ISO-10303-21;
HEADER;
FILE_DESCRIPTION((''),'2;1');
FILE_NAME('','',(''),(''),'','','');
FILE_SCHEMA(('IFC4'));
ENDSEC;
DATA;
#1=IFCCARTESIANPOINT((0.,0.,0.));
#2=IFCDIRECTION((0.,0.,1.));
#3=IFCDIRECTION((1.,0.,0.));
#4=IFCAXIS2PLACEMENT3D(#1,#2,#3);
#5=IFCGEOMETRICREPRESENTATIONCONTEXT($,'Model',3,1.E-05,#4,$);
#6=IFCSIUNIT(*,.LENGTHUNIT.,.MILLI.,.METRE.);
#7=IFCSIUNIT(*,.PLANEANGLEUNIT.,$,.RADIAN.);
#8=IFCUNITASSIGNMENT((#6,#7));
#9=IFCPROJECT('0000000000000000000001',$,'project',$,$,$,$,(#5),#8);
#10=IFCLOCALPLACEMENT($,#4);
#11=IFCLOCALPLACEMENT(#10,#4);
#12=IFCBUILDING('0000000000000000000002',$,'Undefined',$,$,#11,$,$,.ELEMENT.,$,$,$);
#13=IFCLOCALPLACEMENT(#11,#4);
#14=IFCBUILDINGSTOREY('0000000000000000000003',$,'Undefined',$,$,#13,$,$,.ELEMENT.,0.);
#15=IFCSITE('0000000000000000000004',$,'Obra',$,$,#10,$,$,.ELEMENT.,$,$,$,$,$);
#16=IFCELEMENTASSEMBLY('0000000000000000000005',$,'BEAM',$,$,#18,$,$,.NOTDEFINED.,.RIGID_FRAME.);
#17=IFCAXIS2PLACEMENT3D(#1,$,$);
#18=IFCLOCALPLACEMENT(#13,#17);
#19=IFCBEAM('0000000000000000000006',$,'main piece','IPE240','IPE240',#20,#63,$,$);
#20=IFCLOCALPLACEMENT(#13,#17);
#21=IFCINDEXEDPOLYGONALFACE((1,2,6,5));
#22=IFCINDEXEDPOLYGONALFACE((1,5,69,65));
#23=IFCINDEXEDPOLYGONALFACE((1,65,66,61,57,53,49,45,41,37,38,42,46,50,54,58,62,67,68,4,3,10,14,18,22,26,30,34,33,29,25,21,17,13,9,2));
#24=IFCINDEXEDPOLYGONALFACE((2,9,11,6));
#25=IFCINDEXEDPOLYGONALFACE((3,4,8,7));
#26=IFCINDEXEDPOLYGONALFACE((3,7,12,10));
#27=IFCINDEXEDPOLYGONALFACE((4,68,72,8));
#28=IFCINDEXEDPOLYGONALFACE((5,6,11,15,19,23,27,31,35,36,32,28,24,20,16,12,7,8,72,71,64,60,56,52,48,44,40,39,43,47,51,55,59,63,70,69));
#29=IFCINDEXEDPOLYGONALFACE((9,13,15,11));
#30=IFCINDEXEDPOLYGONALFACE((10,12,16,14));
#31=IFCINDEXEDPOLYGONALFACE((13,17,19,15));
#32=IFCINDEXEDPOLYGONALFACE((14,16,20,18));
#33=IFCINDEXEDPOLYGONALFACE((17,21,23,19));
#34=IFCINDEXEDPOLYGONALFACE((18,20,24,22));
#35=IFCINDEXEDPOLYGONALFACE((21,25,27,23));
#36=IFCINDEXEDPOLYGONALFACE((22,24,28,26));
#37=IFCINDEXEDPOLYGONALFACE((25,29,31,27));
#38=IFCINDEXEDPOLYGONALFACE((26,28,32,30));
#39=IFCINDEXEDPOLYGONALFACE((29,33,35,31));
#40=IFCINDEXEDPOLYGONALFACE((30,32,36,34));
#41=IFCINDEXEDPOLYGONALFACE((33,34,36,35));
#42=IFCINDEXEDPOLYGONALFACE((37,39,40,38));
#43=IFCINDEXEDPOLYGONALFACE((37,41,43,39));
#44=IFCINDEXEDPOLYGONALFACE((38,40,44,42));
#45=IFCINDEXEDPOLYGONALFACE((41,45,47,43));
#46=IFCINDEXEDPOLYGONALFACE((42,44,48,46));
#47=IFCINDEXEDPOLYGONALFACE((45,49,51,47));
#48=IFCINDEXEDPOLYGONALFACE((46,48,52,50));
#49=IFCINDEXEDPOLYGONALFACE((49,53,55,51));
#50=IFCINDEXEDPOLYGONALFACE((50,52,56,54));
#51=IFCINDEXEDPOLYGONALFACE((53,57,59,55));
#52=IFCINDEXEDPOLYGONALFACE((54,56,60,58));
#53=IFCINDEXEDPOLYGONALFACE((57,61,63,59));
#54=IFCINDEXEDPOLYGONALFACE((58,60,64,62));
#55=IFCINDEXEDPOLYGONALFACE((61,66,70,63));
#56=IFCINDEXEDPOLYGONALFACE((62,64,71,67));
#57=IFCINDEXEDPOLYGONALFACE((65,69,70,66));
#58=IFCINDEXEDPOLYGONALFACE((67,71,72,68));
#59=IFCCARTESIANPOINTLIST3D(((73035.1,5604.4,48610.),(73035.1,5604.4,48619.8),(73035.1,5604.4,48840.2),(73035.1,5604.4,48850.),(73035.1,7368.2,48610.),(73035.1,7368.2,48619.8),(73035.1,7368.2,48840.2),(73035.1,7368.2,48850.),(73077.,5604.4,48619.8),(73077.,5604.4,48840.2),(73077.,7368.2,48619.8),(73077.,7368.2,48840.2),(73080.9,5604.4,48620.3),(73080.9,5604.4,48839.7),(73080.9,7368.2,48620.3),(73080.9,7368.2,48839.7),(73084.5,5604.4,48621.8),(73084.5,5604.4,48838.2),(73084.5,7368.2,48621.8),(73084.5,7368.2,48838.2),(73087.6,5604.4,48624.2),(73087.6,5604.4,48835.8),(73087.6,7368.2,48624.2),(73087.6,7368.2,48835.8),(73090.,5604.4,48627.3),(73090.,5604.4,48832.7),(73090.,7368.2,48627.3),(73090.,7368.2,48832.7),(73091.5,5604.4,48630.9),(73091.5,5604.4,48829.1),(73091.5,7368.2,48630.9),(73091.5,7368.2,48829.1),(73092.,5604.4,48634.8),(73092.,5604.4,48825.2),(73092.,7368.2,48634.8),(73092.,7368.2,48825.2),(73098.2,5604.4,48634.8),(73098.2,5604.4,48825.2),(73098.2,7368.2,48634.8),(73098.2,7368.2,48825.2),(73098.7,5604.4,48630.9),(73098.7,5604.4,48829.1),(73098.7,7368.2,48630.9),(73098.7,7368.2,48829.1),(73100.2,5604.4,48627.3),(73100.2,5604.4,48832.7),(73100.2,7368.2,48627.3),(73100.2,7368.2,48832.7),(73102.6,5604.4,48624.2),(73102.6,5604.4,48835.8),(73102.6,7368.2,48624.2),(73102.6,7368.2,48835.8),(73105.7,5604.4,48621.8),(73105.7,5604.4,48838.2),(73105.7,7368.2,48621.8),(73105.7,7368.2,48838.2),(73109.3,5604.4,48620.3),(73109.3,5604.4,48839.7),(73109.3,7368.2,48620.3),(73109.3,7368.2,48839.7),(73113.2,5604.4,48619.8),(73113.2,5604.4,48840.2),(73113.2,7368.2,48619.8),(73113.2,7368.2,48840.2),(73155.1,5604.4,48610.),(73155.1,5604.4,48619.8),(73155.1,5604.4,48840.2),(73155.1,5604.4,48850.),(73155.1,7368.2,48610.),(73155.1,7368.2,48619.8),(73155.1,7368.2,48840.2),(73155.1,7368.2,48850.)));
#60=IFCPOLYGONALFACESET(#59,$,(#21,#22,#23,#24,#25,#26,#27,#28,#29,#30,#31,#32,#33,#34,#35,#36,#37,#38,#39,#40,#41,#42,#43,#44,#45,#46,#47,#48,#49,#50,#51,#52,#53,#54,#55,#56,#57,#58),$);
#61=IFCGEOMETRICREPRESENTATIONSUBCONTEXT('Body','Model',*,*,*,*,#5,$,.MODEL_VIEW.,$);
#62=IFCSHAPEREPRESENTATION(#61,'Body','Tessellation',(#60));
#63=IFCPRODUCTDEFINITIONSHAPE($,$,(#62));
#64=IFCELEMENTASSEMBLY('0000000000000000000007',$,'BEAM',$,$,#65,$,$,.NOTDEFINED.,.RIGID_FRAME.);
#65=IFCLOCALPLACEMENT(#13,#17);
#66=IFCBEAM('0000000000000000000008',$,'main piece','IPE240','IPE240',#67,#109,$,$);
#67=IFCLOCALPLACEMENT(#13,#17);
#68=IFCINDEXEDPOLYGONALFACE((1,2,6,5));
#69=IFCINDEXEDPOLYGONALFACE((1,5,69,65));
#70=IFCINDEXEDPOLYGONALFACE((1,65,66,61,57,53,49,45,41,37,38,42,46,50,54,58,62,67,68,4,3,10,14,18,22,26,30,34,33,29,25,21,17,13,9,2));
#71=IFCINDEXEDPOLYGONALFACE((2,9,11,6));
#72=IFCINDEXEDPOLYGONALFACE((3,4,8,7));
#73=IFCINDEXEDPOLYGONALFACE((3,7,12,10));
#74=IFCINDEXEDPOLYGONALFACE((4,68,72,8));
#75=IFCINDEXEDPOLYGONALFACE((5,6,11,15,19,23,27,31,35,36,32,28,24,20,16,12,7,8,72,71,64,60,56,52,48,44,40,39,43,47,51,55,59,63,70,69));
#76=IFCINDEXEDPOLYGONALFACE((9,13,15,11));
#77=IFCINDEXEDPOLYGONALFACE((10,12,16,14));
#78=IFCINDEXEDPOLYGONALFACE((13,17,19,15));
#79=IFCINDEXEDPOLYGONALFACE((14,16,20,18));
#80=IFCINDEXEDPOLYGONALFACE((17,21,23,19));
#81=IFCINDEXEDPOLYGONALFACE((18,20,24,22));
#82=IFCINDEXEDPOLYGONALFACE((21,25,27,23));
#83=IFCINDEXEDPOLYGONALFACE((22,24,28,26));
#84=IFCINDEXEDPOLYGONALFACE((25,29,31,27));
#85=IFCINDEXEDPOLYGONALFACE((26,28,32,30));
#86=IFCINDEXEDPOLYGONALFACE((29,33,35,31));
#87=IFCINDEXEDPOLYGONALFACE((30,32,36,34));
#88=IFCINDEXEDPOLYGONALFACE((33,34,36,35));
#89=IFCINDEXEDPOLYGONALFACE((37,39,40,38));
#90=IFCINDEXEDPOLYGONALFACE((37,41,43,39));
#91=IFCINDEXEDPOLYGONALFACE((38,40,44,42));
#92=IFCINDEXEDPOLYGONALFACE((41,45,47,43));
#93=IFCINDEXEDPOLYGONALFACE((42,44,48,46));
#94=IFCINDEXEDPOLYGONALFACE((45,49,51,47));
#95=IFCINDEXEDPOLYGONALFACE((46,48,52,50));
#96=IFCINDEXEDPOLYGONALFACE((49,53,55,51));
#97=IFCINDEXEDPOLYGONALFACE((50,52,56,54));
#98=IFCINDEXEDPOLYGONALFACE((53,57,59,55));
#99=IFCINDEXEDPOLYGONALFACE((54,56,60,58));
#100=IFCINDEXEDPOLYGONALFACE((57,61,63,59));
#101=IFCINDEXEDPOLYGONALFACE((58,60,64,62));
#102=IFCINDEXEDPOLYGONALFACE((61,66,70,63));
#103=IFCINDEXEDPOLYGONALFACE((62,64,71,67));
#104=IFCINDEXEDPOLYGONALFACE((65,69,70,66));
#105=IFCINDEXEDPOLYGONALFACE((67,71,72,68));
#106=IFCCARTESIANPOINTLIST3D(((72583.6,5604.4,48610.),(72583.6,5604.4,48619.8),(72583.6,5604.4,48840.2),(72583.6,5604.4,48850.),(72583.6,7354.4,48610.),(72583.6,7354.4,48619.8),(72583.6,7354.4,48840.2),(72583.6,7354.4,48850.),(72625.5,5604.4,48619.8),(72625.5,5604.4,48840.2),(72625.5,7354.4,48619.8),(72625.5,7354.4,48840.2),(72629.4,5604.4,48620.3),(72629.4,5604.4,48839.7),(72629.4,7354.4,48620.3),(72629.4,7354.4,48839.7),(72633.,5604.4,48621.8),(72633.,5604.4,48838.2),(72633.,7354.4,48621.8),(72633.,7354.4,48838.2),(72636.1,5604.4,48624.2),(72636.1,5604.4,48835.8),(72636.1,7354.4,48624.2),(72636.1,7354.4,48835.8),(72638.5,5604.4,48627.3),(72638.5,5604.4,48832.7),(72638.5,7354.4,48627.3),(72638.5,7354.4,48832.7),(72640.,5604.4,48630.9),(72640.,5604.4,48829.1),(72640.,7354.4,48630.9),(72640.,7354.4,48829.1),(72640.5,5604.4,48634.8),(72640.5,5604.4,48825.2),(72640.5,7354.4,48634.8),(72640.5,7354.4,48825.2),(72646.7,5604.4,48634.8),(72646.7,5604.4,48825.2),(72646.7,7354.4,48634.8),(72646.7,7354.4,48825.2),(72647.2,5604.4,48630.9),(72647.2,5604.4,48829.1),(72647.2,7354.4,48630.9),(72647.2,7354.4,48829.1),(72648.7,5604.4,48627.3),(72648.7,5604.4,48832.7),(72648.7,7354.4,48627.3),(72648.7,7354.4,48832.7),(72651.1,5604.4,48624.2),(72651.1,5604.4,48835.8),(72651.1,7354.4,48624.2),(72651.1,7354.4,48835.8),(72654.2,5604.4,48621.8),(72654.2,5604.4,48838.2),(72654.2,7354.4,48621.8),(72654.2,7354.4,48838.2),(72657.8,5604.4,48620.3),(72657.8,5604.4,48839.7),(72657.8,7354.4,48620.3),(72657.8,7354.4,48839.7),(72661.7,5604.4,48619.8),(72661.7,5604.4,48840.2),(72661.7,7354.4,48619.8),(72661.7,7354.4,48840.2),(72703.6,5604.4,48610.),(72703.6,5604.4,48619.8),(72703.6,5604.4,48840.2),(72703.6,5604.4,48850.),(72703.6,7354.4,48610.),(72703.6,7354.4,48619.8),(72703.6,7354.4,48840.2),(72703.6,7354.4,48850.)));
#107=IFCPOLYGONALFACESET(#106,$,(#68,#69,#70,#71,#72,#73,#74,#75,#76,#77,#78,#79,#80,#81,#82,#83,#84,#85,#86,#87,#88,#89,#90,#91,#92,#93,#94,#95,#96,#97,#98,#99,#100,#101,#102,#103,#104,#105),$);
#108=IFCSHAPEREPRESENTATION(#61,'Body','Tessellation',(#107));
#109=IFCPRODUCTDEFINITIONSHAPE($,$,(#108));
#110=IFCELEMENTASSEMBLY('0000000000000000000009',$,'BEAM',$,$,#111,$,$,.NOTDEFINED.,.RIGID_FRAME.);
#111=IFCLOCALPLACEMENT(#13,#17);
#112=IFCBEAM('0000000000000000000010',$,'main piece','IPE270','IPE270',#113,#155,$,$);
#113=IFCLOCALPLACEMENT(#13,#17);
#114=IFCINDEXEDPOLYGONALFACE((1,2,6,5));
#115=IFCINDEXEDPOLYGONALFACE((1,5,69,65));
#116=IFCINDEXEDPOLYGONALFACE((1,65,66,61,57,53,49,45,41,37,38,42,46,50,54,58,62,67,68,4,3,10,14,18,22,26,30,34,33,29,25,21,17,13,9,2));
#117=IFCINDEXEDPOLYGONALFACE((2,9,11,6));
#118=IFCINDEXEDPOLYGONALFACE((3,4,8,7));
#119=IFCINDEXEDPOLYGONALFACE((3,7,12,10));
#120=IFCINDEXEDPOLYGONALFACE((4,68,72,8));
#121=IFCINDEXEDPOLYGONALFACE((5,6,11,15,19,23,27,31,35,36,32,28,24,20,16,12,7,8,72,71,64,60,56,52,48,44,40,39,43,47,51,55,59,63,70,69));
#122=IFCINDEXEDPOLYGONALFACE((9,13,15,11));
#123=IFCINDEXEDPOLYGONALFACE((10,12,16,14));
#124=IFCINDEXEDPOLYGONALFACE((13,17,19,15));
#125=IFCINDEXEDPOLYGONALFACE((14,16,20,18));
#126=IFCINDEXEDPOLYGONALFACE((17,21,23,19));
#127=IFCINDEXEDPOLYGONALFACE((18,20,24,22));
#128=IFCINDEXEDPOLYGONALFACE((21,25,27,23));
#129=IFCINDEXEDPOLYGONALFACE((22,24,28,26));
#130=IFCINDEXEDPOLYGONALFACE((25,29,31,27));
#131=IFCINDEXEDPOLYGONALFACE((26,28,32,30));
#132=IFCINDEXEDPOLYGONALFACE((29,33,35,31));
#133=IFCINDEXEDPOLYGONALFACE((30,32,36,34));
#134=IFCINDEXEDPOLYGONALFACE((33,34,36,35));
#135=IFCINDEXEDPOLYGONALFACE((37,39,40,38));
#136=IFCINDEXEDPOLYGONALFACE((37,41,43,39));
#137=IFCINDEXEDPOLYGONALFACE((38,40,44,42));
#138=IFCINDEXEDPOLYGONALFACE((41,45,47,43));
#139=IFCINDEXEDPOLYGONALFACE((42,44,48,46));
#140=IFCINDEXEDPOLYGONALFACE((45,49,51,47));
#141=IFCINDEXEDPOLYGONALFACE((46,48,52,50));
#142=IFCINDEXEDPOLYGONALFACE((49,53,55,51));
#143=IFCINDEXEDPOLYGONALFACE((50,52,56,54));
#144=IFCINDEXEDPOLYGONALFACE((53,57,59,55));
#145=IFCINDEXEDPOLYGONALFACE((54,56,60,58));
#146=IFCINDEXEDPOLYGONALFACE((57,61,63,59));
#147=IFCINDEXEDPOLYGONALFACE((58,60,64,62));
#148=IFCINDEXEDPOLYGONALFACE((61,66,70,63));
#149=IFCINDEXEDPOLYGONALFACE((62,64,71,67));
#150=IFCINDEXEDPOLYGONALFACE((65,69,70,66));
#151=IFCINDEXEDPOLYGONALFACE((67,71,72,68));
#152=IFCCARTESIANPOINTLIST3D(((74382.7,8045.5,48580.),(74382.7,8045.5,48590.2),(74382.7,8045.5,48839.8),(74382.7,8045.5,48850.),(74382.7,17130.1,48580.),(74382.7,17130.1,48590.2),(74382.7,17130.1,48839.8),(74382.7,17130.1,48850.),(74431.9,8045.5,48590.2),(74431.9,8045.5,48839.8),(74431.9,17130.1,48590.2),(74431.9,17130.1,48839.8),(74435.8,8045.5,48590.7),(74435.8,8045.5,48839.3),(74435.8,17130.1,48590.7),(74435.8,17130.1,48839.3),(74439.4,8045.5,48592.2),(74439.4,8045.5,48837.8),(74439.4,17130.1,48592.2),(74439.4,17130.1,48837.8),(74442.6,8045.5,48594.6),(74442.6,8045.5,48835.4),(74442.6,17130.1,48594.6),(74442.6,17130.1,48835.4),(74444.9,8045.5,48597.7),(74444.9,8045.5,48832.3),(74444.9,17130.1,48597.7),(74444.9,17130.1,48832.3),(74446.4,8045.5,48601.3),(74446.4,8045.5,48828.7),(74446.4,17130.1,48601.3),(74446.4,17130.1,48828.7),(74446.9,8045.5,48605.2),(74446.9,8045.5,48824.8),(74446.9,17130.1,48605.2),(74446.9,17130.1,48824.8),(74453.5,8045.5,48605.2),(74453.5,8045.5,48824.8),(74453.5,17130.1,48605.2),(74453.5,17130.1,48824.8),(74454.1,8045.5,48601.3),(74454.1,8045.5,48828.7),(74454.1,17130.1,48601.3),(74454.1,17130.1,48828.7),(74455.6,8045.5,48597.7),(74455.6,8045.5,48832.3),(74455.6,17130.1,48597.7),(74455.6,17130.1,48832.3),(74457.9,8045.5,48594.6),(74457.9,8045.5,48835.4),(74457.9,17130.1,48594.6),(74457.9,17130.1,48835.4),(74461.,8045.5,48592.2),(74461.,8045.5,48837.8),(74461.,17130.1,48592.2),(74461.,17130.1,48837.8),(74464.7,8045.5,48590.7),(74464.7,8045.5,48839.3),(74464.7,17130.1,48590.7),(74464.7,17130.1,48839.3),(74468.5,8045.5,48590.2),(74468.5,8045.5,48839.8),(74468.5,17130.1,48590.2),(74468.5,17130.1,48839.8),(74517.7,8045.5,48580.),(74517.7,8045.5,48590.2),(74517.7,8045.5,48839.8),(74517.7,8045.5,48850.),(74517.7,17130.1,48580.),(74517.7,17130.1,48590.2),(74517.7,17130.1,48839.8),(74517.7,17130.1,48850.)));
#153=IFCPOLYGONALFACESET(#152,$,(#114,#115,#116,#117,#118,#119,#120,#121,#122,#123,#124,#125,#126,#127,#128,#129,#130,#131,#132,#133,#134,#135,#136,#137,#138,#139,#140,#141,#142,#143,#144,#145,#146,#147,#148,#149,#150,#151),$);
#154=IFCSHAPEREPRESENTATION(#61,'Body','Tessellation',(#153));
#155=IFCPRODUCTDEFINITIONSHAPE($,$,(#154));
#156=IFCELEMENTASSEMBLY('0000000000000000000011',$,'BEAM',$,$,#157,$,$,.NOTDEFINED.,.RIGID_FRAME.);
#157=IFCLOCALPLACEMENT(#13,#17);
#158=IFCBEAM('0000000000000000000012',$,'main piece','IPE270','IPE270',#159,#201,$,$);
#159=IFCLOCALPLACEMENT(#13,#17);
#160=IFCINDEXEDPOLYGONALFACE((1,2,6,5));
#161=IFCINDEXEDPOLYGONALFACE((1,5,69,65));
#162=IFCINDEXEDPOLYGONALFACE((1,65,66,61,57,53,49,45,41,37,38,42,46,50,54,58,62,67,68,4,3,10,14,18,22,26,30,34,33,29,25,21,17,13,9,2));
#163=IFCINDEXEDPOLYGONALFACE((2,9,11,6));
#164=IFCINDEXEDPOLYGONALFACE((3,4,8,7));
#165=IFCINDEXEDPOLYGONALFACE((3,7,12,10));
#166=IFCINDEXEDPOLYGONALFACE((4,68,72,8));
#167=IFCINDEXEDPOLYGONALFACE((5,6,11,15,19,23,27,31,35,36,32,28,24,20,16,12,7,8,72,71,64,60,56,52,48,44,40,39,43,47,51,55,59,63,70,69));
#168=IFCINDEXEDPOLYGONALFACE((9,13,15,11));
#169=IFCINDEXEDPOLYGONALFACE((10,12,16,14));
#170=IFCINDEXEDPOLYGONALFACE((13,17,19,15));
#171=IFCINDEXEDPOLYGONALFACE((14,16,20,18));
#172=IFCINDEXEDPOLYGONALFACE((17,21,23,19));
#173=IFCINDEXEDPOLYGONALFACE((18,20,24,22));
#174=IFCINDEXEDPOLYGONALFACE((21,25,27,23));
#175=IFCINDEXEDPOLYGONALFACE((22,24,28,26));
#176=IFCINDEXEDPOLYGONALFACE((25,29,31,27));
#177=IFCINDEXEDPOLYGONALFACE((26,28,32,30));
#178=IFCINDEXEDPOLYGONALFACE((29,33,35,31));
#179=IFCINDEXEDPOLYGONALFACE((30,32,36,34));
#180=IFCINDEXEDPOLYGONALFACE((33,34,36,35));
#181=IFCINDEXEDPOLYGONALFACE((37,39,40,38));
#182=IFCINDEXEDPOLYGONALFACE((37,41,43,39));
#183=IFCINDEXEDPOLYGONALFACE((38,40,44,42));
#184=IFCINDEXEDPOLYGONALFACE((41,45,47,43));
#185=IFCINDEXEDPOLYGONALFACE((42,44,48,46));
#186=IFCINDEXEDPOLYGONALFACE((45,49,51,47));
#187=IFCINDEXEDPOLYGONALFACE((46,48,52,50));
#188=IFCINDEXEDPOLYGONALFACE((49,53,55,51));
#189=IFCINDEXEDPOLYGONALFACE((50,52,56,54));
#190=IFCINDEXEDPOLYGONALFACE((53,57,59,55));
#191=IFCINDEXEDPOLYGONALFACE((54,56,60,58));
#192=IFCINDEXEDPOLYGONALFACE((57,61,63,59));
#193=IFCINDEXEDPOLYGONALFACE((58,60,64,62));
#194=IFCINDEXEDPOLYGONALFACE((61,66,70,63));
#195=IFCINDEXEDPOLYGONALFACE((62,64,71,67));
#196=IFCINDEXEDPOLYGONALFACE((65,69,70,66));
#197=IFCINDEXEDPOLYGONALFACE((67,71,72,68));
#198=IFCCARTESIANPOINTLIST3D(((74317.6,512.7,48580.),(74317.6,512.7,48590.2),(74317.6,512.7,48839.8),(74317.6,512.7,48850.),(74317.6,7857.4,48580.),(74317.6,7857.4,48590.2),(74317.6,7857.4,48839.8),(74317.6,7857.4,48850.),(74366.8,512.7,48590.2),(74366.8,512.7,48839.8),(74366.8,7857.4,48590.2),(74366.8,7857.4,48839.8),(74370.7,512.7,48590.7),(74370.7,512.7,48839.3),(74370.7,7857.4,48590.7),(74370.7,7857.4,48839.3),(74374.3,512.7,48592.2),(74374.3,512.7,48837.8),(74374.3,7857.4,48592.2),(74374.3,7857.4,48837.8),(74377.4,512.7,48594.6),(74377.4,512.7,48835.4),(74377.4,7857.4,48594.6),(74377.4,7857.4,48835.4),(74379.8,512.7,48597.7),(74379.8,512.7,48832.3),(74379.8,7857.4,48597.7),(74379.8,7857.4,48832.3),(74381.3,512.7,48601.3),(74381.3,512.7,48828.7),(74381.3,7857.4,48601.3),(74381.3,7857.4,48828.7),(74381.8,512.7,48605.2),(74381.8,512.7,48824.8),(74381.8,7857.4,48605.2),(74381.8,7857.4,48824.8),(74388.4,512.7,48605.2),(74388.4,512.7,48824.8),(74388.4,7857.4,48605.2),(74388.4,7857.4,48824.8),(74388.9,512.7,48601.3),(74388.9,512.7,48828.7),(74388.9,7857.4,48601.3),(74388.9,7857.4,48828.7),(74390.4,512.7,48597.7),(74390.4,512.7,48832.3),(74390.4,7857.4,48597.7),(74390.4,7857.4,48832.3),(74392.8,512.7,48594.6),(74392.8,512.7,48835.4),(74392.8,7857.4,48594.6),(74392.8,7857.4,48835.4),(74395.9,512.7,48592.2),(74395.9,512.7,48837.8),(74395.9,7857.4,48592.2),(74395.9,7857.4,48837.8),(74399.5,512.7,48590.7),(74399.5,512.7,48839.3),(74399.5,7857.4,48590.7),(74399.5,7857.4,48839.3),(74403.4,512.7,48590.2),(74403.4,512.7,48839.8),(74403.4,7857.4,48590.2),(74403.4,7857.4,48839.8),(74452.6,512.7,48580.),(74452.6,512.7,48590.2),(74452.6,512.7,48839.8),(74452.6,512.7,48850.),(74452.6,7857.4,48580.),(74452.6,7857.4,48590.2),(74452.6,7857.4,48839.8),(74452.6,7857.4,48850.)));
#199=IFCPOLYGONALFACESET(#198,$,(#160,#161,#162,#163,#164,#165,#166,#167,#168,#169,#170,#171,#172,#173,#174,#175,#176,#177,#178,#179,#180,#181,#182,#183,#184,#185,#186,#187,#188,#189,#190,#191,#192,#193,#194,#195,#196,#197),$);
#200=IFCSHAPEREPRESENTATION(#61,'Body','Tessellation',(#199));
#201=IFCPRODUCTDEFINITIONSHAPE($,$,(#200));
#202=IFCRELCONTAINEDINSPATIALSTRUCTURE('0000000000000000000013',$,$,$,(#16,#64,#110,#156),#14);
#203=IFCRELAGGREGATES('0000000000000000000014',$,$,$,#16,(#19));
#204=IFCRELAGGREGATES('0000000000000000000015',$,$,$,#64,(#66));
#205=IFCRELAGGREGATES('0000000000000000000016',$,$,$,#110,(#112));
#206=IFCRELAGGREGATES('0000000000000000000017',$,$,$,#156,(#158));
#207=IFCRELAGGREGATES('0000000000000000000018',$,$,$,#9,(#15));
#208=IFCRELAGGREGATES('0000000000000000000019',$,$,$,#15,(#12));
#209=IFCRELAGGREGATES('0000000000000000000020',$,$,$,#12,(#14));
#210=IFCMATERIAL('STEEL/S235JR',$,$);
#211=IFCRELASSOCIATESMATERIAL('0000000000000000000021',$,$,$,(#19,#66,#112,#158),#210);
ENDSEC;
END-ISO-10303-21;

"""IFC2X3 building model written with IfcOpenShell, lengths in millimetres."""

from ifc_helpers import new_model, si_unit, frame, origin_with_axes, origin_2d_with_axis, place, context, subcontext, project, spatial, i_section, extrude, material, element, aggregate, save


model = new_model("IFC2X3")

# Units and contexts
model_context = context("Model", 3, precision=1e-05, world=origin_with_axes())
body_context = subcontext(model_context, "Body", "Model", "MODEL_VIEW")
ifc_project = project(units=[si_unit("LENGTHUNIT", "METRE", prefix="MILLI"), si_unit("PLANEANGLEUNIT", "RADIAN")], contexts=[model_context])

# Site, building, storey
site_placement = place(None, origin_with_axes())
site = spatial("IfcSite", under=ifc_project, at=site_placement, Name="Obra", CompositionType="ELEMENT")
building_placement = place(site_placement, origin_with_axes())
building = spatial("IfcBuilding", under=site, at=building_placement, Name="Undefined", CompositionType="ELEMENT")
storey_placement = place(building_placement, origin_with_axes())
storey = spatial("IfcBuildingStorey", under=building, at=storey_placement, Name="Undefined", CompositionType="ELEMENT", Elevation=0.0)

# Shared definitions
ifc_material_1 = material(Name="STEEL/S235JR")

# Element assemblies, beams
assembly_1_placement = place(storey_placement, origin_with_axes())
assembly_1 = element("IfcElementAssembly", 1, at=assembly_1_placement, inside=storey, Name="BEAM", AssemblyPlace="NOTDEFINED", PredefinedType="RIGID_FRAME")
beam_1_placement = place(assembly_1_placement, frame((73095.1, 7368.2, 48730.0), z_axis=(0.0, 0.0, 1.0), x_axis=(0.0, -1.0, 0.0)))
beam_1 = element("IfcBeam", 2, at=beam_1_placement, material=ifc_material_1, Name="main piece", Description="IPE240", ObjectType="IPE240", context=body_context, shape_type="SweptSolid", body=[
    extrude(i_section(OverallWidth=120.0, OverallDepth=240.0, WebThickness=6.2, FlangeThickness=9.8, FilletRadius=15.0, at=origin_2d_with_axis()), frame((1763.8, 0.0, 0.0), z_axis=(-1.0, 0.0, 0.0), x_axis=(0.0, -1.0, 0.0)), (0.0, 0.0, 1.0), 1763.8),
])
aggregate(assembly_1, [beam_1])
assembly_2_placement = place(storey_placement, origin_with_axes())
assembly_2 = element("IfcElementAssembly", 3, at=assembly_2_placement, inside=storey, Name="BEAM", AssemblyPlace="NOTDEFINED", PredefinedType="RIGID_FRAME")
beam_2_placement = place(assembly_2_placement, frame((72643.6, 5604.4, 48730.0), z_axis=(0.0, 0.0, 1.0), x_axis=(0.0, 1.0, 0.0)))
beam_2 = element("IfcBeam", 4, at=beam_2_placement, material=ifc_material_1, Name="main piece", Description="IPE240", ObjectType="IPE240", context=body_context, shape_type="SweptSolid", body=[
    extrude(i_section(OverallWidth=120.0, OverallDepth=240.0, WebThickness=6.2, FlangeThickness=9.8, FilletRadius=15.0, at=origin_2d_with_axis()), frame((1750.0, 0.0, 0.0), z_axis=(-1.0, 0.0, 0.0), x_axis=(0.0, -1.0, 0.0)), (0.0, 0.0, 1.0), 1750.0),
])
aggregate(assembly_2, [beam_2])
assembly_3_placement = place(storey_placement, origin_with_axes())
assembly_3 = element("IfcElementAssembly", 5, at=assembly_3_placement, inside=storey, Name="BEAM", AssemblyPlace="NOTDEFINED", PredefinedType="RIGID_FRAME")
beam_3_placement = place(assembly_3_placement, frame((74450.2, 8045.5, 48715.0), z_axis=(0.0, 0.0, 1.0), x_axis=(0.0, 1.0, 0.0)))
beam_3 = element("IfcBeam", 6, at=beam_3_placement, material=ifc_material_1, Name="main piece", Description="IPE270", ObjectType="IPE270", context=body_context, shape_type="SweptSolid", body=[
    extrude(i_section(OverallWidth=135.0, OverallDepth=270.0, WebThickness=6.6, FlangeThickness=10.2, FilletRadius=15.0, at=origin_2d_with_axis()), frame((9084.6, 0.0, 0.0), z_axis=(-1.0, 0.0, 0.0), x_axis=(0.0, -1.0, 0.0)), (0.0, 0.0, 1.0), 9084.6),
])
aggregate(assembly_3, [beam_3])
assembly_4_placement = place(storey_placement, origin_with_axes())
assembly_4 = element("IfcElementAssembly", 7, at=assembly_4_placement, inside=storey, Name="BEAM", AssemblyPlace="NOTDEFINED", PredefinedType="RIGID_FRAME")
beam_4_placement = place(assembly_4_placement, frame((74385.1, 512.7, 48715.0), z_axis=(0.0, 0.0, 1.0), x_axis=(0.0, 1.0, 0.0)))
beam_4 = element("IfcBeam", 8, at=beam_4_placement, material=ifc_material_1, Name="main piece", Description="IPE270", ObjectType="IPE270", context=body_context, shape_type="SweptSolid", body=[
    extrude(i_section(OverallWidth=135.0, OverallDepth=270.0, WebThickness=6.6, FlangeThickness=10.2, FilletRadius=15.0, at=origin_2d_with_axis()), frame((7344.7, 0.0, 0.0), z_axis=(-1.0, 0.0, 0.0), x_axis=(0.0, -1.0, 0.0)), (0.0, 0.0, 1.0), 7344.7),
])
aggregate(assembly_4, [beam_4])

save(model, "model.ifc")
